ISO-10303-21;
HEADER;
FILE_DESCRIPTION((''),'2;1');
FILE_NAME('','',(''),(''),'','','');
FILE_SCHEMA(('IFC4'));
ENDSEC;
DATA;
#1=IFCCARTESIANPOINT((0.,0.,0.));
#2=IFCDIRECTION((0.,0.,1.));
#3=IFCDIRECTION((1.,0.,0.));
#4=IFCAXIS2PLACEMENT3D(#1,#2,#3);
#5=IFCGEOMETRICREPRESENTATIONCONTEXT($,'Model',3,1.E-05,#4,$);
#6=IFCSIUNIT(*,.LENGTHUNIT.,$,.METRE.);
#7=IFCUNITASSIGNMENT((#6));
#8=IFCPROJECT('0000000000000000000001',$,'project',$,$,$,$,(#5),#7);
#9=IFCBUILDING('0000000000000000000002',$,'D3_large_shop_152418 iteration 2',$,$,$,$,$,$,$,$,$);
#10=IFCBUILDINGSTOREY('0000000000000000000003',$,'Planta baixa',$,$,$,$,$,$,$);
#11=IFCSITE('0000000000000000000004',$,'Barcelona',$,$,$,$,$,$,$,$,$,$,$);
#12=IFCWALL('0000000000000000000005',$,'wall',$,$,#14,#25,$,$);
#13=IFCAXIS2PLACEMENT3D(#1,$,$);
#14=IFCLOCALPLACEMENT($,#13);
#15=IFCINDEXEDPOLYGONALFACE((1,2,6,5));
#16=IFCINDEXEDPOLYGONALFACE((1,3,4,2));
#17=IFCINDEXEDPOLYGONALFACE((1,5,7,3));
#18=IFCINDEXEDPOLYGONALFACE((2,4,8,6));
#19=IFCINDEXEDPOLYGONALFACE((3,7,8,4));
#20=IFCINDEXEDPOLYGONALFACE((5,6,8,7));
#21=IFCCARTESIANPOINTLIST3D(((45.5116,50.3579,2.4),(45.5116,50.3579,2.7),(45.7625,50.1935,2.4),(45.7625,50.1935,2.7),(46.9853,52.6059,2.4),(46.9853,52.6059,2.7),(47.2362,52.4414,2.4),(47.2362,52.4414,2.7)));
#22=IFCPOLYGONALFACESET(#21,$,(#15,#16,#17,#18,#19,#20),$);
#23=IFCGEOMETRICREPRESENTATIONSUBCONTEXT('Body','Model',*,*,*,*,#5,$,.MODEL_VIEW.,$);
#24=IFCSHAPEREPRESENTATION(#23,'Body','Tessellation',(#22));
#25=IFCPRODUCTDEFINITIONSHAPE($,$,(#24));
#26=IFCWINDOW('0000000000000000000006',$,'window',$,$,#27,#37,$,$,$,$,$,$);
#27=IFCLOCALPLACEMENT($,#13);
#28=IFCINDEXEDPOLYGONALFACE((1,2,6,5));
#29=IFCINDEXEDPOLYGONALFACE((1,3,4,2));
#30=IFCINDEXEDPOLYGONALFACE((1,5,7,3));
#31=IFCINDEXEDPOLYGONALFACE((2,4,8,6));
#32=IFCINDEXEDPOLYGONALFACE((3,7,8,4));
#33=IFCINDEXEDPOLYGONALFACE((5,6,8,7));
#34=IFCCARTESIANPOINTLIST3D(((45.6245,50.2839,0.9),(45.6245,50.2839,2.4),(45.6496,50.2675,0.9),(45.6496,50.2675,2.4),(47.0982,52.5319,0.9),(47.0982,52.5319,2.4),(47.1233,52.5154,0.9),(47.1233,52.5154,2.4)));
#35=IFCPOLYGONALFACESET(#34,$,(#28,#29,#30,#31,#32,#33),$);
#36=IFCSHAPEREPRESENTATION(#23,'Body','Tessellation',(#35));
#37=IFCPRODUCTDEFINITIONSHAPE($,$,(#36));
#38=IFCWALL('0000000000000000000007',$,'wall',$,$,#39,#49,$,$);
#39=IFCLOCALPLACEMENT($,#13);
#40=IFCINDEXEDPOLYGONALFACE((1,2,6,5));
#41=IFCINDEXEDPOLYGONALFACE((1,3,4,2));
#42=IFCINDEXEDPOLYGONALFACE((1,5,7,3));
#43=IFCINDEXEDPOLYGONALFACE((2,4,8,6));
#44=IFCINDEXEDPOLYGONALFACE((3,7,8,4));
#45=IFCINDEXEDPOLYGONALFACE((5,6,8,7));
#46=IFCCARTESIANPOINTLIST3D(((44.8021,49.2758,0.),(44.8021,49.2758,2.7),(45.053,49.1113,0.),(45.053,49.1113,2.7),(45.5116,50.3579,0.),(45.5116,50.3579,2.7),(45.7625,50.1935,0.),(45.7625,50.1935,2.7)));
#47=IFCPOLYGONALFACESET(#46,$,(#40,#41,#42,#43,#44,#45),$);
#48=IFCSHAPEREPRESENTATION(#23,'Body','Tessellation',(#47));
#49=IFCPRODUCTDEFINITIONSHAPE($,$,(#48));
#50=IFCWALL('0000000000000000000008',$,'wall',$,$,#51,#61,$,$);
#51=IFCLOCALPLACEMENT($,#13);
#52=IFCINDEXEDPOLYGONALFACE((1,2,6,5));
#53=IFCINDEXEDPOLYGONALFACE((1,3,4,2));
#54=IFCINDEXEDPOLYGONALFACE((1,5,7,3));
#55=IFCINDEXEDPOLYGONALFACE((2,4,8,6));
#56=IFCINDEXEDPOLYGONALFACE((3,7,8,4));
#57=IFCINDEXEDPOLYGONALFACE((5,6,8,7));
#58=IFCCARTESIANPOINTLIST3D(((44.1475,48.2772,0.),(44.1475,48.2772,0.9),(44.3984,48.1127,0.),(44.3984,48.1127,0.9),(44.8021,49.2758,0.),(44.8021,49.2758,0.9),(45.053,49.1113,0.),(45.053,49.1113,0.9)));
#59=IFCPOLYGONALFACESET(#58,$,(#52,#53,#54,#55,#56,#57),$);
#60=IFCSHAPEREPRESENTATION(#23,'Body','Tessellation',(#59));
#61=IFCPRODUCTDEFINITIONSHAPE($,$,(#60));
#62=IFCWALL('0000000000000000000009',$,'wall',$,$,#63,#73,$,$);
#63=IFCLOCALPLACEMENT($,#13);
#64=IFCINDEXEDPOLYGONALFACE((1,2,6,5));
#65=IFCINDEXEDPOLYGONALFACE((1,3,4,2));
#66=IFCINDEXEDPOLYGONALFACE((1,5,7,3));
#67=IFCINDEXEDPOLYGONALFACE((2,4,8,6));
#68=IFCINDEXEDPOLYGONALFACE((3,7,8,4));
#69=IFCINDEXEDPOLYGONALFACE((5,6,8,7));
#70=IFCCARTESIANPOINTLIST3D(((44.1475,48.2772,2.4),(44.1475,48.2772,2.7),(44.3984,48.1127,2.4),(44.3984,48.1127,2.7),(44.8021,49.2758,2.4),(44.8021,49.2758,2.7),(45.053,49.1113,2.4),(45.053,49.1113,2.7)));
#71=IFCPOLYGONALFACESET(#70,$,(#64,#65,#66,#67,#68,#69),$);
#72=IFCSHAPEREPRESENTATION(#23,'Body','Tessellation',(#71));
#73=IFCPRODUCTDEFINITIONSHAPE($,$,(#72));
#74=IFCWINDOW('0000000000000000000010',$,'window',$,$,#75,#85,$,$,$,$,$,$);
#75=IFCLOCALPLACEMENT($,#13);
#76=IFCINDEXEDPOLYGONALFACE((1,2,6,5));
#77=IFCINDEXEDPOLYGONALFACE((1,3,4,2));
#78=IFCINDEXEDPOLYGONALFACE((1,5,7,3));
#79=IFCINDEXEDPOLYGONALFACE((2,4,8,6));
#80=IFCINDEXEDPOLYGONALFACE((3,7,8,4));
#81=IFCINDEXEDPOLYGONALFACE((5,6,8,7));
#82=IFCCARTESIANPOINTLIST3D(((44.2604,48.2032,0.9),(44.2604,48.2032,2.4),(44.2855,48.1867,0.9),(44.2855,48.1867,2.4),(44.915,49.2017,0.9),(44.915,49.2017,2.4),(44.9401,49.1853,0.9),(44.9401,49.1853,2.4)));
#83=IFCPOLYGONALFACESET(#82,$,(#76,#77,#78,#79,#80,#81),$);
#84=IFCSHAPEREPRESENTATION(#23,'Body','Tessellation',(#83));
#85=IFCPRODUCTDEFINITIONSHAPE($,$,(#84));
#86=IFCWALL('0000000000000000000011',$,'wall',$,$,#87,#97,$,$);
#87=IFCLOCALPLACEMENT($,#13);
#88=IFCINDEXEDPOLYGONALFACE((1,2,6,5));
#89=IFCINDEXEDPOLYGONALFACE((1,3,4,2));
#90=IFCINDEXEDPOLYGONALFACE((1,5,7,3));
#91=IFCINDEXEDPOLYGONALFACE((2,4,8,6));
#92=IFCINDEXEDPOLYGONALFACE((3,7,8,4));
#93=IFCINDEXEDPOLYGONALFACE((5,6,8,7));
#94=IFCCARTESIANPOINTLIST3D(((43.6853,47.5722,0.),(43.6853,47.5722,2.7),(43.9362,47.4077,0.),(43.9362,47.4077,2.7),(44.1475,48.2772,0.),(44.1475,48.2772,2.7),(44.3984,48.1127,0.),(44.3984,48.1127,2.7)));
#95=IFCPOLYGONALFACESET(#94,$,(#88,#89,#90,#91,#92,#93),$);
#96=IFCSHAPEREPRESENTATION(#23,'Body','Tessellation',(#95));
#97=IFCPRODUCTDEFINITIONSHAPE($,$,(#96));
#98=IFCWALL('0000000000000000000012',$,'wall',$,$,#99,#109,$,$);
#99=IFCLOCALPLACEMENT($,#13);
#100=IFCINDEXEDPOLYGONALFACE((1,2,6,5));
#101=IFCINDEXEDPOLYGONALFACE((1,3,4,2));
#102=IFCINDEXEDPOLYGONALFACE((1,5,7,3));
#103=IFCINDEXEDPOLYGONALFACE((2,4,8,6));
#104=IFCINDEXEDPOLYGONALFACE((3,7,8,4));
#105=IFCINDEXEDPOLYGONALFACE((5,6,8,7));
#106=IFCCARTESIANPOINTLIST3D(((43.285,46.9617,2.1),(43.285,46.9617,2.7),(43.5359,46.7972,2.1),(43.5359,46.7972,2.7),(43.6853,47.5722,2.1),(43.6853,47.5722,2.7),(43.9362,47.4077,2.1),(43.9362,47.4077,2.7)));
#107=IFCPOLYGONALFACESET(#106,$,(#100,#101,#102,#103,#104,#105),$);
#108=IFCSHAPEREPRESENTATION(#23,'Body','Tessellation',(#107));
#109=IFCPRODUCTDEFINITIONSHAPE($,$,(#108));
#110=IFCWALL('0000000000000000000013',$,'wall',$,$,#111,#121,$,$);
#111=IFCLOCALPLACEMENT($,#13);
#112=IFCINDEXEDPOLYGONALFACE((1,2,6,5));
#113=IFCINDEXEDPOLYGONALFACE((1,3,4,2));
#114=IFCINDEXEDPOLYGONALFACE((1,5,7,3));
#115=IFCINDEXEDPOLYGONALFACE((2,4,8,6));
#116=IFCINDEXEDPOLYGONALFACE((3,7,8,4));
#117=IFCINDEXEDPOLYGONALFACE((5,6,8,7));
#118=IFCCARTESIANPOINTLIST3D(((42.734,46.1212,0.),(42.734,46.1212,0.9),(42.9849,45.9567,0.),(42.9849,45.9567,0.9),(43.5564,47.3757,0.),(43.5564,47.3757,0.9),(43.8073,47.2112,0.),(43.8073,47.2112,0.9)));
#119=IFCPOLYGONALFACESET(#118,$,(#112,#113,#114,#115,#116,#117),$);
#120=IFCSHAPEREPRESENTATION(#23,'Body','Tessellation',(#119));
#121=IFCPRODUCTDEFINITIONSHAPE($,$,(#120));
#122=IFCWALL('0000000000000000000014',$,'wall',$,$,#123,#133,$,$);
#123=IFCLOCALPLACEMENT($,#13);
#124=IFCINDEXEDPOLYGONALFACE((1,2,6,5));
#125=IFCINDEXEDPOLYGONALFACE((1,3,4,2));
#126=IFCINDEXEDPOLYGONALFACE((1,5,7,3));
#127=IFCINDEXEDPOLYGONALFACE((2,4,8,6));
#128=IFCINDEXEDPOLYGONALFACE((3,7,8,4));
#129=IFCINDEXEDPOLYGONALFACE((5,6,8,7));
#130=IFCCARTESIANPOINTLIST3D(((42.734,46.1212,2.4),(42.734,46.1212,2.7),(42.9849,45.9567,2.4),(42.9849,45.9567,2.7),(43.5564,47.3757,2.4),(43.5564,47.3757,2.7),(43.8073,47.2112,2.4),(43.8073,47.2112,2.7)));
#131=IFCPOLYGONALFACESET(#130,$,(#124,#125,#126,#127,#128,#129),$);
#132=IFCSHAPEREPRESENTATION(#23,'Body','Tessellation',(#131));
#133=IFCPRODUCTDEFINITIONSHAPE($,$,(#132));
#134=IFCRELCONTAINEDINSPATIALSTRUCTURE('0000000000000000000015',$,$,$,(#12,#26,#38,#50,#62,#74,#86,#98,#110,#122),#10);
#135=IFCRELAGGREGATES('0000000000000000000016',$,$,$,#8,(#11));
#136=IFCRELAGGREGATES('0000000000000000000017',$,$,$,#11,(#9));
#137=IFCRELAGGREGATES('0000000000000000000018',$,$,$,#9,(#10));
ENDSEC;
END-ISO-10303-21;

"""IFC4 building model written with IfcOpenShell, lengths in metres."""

from ifc_helpers import new_model, si_unit, frame, origin, origin_with_axes, place, context, subcontext, project, spatial, polyline, outline, extrude, element, save


model = new_model("IFC4")

# Units and contexts
model_context = context("Model", 3, precision=1e-05, world=origin_with_axes())
body_context = subcontext(model_context, "Body", "Model", "MODEL_VIEW")
ifc_project = project(units=[si_unit("LENGTHUNIT", "METRE")], contexts=[model_context])

# Site, building, storey
site = spatial("IfcSite", under=ifc_project, Name="Barcelona")
building = spatial("IfcBuilding", under=site, Name="D3_large_shop_152418 iteration 2")
storey = spatial("IfcBuildingStorey", under=building, Name="Planta baixa")

# Wall
wall_1_placement = place(None, origin_with_axes())
element("IfcWall", 1, at=wall_1_placement, inside=storey, Name="wall", context=body_context, shape_type="SweptSolid", body=[
    extrude(outline(polyline([(47.2362, 52.4414), (45.7625, 50.1935), (45.5116, 50.3579), (46.9853, 52.6059), (47.2362, 52.4414)])), frame((0.0, 0.0, 2.4)), (0.0, 0.0, 1.0), 0.3),
])

# Window
window_1_placement = place(None, origin_with_axes())
element("IfcWindow", 2, at=window_1_placement, inside=storey, Name="window", context=body_context, shape_type="SweptSolid", body=[
    extrude(outline(polyline([(47.1233, 52.5154), (45.6496, 50.2675), (45.6245, 50.2839), (47.0982, 52.5319), (47.1233, 52.5154)])), frame((0.0, 0.0, 0.9)), (0.0, 0.0, 1.0), 1.5),
])

# Walls
wall_2_placement = place(None, origin_with_axes())
element("IfcWall", 3, at=wall_2_placement, inside=storey, Name="wall", context=body_context, shape_type="SweptSolid", body=[
    extrude(outline(polyline([(45.7625, 50.1935), (45.053, 49.1113), (44.8021, 49.2758), (45.5116, 50.3579), (45.7625, 50.1935)])), origin(), (0.0, 0.0, 1.0), 2.7),
])
wall_3_placement = place(None, origin_with_axes())
element("IfcWall", 4, at=wall_3_placement, inside=storey, Name="wall", context=body_context, shape_type="SweptSolid", body=[
    extrude(outline(polyline([(45.053, 49.1113), (44.3984, 48.1127), (44.1475, 48.2772), (44.8021, 49.2758), (45.053, 49.1113)])), origin(), (0.0, 0.0, 1.0), 0.9),
])
wall_4_placement = place(None, origin_with_axes())
element("IfcWall", 5, at=wall_4_placement, inside=storey, Name="wall", context=body_context, shape_type="SweptSolid", body=[
    extrude(outline(polyline([(45.053, 49.1113), (44.3984, 48.1127), (44.1475, 48.2772), (44.8021, 49.2758), (45.053, 49.1113)])), frame((0.0, 0.0, 2.4)), (0.0, 0.0, 1.0), 0.3),
])

# Window
window_2_placement = place(None, origin_with_axes())
element("IfcWindow", 6, at=window_2_placement, inside=storey, Name="window", context=body_context, shape_type="SweptSolid", body=[
    extrude(outline(polyline([(44.9401, 49.1853), (44.2855, 48.1867), (44.2604, 48.2032), (44.915, 49.2017), (44.9401, 49.1853)])), frame((0.0, 0.0, 0.9)), (0.0, 0.0, 1.0), 1.5),
])

# Walls
wall_5_placement = place(None, origin_with_axes())
element("IfcWall", 7, at=wall_5_placement, inside=storey, Name="wall", context=body_context, shape_type="SweptSolid", body=[
    extrude(outline(polyline([(44.3984, 48.1127), (43.9362, 47.4077), (43.6853, 47.5722), (44.1475, 48.2772), (44.3984, 48.1127)])), origin(), (0.0, 0.0, 1.0), 2.7),
])
wall_6_placement = place(None, origin_with_axes())
element("IfcWall", 8, at=wall_6_placement, inside=storey, Name="wall", context=body_context, shape_type="SweptSolid", body=[
    extrude(outline(polyline([(43.9362, 47.4077), (43.5359, 46.7972), (43.285, 46.9617), (43.6853, 47.5722), (43.9362, 47.4077)])), frame((0.0, 0.0, 2.1)), (0.0, 0.0, 1.0), 0.6),
])
wall_7_placement = place(None, origin_with_axes())
element("IfcWall", 9, at=wall_7_placement, inside=storey, Name="wall", context=body_context, shape_type="SweptSolid", body=[
    extrude(outline(polyline([(43.8073, 47.2112), (42.9849, 45.9567), (42.734, 46.1212), (43.5564, 47.3757), (43.8073, 47.2112)])), origin(), (0.0, 0.0, 1.0), 0.9),
])
wall_8_placement = place(None, origin_with_axes())
element("IfcWall", 10, at=wall_8_placement, inside=storey, Name="wall", context=body_context, shape_type="SweptSolid", body=[
    extrude(outline(polyline([(43.8073, 47.2112), (42.9849, 45.9567), (42.734, 46.1212), (43.5564, 47.3757), (43.8073, 47.2112)])), frame((0.0, 0.0, 2.4)), (0.0, 0.0, 1.0), 0.3),
])

save(model, "model.ifc")
